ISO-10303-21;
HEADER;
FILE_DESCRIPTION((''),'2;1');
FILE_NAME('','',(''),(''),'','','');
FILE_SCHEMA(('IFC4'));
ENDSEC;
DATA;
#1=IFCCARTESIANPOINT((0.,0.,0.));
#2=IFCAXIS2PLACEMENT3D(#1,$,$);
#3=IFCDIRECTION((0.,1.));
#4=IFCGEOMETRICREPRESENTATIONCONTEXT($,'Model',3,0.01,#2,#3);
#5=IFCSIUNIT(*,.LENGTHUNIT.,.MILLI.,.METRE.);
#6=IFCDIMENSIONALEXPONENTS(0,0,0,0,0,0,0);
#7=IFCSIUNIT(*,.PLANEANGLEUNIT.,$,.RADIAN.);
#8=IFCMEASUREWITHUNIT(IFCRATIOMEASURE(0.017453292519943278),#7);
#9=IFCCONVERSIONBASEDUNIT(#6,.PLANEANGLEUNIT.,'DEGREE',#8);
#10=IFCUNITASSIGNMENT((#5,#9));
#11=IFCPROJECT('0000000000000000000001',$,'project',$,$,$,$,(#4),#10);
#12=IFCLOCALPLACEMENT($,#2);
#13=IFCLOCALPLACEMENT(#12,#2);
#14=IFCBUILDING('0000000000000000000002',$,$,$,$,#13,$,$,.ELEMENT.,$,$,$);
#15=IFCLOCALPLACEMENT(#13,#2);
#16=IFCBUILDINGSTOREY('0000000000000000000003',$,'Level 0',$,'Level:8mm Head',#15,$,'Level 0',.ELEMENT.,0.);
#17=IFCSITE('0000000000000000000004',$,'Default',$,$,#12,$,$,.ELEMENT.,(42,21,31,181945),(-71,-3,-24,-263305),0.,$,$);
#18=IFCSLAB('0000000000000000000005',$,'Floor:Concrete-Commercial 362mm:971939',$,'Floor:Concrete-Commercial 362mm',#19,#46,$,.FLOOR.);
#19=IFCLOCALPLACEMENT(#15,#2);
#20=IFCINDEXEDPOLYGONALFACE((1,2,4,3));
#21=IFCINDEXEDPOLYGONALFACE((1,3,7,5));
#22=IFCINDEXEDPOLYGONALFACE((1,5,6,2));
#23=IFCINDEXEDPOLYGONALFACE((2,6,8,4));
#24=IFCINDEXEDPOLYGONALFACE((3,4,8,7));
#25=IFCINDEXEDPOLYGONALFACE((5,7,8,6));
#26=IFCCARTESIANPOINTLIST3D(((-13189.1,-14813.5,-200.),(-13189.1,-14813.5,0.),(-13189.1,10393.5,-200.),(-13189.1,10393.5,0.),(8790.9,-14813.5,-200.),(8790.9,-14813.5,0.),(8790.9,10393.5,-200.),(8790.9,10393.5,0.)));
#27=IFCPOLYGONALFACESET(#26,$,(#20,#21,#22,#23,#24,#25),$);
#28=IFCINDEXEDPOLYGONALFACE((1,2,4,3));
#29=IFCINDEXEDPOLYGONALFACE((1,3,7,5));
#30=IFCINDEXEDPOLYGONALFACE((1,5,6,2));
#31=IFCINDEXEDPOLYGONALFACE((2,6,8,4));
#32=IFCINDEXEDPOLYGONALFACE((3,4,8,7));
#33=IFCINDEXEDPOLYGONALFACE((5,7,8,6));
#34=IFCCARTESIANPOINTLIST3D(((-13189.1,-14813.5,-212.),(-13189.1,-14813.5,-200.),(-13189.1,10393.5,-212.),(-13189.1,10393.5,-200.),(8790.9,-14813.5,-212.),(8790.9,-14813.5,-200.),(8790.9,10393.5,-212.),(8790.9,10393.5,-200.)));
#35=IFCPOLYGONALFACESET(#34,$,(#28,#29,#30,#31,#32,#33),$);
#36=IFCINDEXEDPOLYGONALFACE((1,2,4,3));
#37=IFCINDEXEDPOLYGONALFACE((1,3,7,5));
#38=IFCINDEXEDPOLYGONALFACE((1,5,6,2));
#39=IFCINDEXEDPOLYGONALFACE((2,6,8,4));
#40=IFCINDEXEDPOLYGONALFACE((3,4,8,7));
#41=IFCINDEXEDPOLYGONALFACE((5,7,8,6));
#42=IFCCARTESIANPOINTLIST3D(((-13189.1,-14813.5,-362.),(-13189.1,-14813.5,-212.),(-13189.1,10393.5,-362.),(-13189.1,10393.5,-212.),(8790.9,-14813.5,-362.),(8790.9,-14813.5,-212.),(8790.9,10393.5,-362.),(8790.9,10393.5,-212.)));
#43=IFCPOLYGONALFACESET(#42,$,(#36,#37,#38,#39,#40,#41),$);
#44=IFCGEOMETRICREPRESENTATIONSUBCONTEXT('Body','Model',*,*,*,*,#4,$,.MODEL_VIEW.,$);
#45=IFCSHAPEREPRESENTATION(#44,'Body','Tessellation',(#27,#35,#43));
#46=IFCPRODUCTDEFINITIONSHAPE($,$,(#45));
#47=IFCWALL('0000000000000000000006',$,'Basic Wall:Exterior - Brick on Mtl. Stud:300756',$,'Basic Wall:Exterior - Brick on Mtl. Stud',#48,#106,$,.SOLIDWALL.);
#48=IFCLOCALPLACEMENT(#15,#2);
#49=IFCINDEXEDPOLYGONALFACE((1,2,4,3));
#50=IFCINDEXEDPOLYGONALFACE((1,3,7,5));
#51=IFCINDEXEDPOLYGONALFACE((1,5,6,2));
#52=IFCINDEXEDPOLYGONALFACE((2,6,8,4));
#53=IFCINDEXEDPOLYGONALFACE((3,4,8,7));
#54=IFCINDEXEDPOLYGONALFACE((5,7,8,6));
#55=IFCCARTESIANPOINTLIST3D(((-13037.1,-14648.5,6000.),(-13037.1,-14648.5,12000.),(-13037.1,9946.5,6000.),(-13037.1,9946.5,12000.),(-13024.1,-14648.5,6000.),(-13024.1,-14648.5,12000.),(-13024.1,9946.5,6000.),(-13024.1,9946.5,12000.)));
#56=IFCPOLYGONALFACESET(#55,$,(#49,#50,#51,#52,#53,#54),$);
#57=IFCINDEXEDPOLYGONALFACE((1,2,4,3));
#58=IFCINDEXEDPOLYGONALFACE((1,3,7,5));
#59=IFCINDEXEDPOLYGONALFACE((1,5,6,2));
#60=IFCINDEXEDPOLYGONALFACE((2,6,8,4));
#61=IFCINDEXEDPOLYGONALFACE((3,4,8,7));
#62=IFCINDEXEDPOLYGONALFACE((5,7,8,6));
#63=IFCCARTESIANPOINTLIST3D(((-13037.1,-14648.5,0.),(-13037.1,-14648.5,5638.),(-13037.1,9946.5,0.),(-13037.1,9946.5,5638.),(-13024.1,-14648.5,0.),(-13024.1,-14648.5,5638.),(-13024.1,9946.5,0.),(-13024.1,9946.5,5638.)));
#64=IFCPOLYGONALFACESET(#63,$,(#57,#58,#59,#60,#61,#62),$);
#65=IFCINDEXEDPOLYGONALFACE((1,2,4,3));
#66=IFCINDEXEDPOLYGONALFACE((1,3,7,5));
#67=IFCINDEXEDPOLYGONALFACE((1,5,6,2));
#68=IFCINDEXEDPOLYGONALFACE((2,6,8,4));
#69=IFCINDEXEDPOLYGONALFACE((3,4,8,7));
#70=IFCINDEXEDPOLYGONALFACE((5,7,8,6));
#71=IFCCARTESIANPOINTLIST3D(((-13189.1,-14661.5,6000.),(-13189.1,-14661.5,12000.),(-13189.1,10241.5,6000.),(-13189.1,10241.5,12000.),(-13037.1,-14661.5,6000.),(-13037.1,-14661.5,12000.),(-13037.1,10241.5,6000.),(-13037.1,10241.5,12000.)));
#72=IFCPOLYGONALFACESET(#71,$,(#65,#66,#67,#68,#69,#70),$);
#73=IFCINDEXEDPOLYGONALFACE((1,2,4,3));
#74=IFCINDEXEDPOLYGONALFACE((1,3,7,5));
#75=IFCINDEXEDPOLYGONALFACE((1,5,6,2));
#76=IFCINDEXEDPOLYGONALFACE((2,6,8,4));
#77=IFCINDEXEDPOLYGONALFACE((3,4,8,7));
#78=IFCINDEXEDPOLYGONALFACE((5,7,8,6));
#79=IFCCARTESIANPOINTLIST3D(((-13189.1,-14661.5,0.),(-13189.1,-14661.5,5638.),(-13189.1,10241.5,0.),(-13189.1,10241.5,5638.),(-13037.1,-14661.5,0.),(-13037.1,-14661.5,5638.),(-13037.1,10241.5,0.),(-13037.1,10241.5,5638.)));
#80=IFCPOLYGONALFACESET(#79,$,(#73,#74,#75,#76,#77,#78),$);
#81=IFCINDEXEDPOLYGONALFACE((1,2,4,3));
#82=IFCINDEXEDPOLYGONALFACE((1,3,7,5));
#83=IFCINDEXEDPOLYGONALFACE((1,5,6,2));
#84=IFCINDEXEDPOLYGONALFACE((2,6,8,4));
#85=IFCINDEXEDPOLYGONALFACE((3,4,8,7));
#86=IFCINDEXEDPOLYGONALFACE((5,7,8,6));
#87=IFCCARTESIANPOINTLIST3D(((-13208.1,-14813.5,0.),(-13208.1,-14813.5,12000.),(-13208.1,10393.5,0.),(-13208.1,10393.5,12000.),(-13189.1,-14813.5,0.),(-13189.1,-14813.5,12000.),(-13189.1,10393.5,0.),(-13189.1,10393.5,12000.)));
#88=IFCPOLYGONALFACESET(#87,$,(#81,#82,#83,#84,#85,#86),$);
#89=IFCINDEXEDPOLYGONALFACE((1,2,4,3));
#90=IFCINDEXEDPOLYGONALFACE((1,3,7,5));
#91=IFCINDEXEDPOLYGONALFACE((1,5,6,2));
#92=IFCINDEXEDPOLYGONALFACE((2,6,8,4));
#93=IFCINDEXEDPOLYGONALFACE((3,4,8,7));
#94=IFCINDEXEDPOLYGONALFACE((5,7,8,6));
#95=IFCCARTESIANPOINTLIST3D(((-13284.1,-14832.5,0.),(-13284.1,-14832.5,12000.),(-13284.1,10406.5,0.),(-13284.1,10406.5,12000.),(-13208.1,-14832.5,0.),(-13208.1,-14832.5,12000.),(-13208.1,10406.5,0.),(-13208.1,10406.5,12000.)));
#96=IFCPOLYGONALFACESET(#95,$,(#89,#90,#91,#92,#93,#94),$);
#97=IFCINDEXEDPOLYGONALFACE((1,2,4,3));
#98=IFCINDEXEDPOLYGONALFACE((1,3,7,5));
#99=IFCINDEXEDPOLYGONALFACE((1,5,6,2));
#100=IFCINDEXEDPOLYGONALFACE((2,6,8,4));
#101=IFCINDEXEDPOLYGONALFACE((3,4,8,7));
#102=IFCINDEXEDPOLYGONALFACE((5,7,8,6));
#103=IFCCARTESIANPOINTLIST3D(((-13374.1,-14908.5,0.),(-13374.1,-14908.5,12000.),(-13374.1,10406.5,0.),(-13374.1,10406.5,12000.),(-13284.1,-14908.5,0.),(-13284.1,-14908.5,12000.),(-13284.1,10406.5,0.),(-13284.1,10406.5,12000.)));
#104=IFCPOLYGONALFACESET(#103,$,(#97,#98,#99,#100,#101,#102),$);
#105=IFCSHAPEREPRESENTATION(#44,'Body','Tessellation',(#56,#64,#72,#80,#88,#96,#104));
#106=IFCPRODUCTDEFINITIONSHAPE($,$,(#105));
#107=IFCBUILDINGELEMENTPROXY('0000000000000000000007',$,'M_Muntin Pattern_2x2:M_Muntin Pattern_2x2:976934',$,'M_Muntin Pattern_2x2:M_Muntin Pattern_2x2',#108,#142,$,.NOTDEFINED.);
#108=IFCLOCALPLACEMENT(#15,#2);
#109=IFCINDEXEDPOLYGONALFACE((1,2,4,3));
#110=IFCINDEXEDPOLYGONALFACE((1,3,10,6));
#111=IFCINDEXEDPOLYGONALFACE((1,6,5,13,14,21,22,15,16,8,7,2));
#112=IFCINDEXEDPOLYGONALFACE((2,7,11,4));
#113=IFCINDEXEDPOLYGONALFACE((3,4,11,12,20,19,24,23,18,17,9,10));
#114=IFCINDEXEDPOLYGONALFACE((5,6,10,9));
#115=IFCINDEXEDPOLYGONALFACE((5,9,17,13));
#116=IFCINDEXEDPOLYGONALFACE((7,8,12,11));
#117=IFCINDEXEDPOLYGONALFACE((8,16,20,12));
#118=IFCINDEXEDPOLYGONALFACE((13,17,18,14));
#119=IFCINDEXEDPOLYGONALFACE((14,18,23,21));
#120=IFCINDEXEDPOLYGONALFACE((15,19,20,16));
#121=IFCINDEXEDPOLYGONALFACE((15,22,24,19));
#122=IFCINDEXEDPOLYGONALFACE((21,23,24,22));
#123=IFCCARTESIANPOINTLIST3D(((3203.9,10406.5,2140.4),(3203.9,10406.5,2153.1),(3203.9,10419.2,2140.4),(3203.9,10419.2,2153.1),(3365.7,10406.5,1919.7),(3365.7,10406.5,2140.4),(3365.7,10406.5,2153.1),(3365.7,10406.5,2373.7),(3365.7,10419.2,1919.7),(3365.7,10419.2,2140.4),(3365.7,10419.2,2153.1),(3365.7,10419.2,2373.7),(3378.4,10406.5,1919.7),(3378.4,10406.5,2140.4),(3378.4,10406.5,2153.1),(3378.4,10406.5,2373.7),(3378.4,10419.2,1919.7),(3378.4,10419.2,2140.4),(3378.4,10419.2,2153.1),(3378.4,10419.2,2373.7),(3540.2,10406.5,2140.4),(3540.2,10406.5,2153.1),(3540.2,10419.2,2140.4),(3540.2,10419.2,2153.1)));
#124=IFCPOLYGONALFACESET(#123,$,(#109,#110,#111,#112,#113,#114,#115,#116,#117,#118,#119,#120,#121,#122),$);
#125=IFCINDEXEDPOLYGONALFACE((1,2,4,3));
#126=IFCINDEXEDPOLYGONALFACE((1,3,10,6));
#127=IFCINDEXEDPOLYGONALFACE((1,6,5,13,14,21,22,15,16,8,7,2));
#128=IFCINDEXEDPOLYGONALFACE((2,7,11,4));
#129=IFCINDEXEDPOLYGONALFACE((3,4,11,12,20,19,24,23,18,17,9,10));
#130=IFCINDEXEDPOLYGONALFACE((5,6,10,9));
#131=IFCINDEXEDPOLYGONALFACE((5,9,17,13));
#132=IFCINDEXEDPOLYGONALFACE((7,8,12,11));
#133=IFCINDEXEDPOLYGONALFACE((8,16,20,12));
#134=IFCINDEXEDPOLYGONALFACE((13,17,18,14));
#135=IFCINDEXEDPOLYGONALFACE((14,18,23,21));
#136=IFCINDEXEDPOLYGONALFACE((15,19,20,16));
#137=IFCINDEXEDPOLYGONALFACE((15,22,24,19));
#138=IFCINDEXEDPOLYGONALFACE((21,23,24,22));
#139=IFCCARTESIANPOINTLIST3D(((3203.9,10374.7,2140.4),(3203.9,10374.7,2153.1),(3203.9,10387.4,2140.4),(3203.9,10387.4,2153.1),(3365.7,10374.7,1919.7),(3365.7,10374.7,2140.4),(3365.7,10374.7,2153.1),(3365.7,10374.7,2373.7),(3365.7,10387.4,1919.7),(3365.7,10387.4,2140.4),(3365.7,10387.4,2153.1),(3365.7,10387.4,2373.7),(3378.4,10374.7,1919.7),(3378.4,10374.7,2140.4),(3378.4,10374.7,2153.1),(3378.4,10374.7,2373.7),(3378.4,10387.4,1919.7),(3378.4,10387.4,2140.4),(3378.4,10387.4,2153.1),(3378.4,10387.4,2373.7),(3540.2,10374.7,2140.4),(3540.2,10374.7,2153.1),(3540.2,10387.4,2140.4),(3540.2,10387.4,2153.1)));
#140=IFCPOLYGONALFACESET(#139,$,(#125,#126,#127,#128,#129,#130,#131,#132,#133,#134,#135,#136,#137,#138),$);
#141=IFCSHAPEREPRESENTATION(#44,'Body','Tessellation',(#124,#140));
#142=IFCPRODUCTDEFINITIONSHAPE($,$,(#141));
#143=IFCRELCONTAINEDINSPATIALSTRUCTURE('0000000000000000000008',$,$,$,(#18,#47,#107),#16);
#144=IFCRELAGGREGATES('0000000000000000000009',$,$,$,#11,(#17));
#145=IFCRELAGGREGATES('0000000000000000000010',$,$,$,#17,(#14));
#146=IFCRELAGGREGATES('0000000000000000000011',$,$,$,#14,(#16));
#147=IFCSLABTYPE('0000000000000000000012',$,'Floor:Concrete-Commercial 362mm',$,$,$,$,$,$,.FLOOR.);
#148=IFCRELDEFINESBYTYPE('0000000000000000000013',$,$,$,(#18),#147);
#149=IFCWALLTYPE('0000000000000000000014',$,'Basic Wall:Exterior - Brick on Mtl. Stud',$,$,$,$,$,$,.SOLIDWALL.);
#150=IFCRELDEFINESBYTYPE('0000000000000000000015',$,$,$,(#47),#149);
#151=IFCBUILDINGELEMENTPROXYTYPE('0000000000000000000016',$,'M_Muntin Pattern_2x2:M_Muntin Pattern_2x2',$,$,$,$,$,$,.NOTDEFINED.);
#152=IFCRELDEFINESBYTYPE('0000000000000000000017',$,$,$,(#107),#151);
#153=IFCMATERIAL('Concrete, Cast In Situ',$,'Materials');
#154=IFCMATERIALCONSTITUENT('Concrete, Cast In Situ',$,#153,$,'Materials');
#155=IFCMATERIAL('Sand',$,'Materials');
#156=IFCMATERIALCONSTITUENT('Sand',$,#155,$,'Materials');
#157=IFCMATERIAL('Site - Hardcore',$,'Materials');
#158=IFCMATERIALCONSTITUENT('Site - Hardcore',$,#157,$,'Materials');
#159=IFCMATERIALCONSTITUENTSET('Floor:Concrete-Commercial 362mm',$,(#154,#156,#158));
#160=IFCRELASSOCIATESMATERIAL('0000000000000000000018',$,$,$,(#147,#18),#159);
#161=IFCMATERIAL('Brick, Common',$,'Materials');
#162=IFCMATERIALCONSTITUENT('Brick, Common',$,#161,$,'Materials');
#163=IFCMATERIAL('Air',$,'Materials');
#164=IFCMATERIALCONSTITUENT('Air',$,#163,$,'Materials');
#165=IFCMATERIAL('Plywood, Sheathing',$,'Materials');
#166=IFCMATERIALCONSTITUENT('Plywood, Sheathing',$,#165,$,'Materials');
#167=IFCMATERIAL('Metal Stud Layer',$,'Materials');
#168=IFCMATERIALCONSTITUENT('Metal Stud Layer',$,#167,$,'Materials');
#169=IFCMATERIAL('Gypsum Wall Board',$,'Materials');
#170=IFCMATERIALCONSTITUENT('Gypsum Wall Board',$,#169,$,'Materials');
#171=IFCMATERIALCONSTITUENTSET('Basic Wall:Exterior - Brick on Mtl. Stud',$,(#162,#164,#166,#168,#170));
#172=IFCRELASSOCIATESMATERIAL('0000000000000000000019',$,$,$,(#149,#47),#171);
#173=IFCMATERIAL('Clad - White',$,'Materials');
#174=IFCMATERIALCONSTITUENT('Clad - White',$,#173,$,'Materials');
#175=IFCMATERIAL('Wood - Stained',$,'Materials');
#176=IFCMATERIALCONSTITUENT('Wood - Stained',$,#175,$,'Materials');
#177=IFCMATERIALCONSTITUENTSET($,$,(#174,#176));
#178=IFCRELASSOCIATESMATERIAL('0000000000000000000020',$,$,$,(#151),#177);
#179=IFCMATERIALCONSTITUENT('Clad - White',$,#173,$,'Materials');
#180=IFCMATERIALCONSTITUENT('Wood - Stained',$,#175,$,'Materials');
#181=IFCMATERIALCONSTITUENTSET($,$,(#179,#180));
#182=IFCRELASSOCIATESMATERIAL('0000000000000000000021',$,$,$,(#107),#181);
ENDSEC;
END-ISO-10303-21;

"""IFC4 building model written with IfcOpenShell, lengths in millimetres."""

from ifc_helpers import new_model, entity, si_unit, converted_unit, direction, frame, origin, place, context, subcontext, project, spatial, indexed_curve, outline, extrude, source, transform, mapped, material, constituent, constituent_set, type_object, type_shapes, element, save


model = new_model("IFC4")

# Units and contexts
model_context = context("Model", 3, precision=0.01, world=origin(), true_north=direction((0.0, 1.0)))
body_context = subcontext(model_context, "Body", "Model", "MODEL_VIEW")
ifc_project = project(units=[si_unit("LENGTHUNIT", "METRE", prefix="MILLI"), converted_unit("PLANEANGLEUNIT", "DEGREE", entity("IfcRatioMeasure", 0.017453292519943278), si_unit("PLANEANGLEUNIT", "RADIAN"), dimensions=[0, 0, 0, 0, 0, 0, 0])], contexts=[model_context])

# Site, building, storey
site_placement = place(None, origin())
site = spatial("IfcSite", under=ifc_project, at=site_placement, Name="Default", CompositionType="ELEMENT", RefLatitude=(42, 21, 31, 181945), RefLongitude=(-71, -3, -24, -263305), RefElevation=0.0)
building_placement = place(site_placement, origin())
building = spatial("IfcBuilding", under=site, at=building_placement, CompositionType="ELEMENT")
storey_placement = place(building_placement, origin())
storey = spatial("IfcBuildingStorey", under=building, at=storey_placement, Name="Level 0", ObjectType="Level:8mm Head", LongName="Level 0", CompositionType="ELEMENT", Elevation=0.0)

# Slab
ifc_material_1 = material(Name="Concrete, Cast In Situ", Category="Materials")
ifc_constituent_1 = constituent(ifc_material_1, Name="Concrete, Cast In Situ", Category="Materials")
ifc_material_2 = material(Name="Sand", Category="Materials")
ifc_constituent_2 = constituent(ifc_material_2, Name="Sand", Category="Materials")
ifc_material_3 = material(Name="Site - Hardcore", Category="Materials")
ifc_constituent_3 = constituent(ifc_material_3, Name="Site - Hardcore", Category="Materials")
ifc_constituent_set_1 = constituent_set(constituents=[ifc_constituent_1, ifc_constituent_2, ifc_constituent_3], Name="Floor:Concrete-Commercial 362mm")
slab_type = type_object("IfcSlabType", Name="Floor:Concrete-Commercial 362mm", PredefinedType="FLOOR", material=ifc_constituent_set_1)
slab_placement = place(storey_placement, origin())
element("IfcSlab", 1, at=slab_placement, inside=storey, type_object=slab_type, material=ifc_constituent_set_1, Name="Floor:Concrete-Commercial 362mm:971939", ObjectType="Floor:Concrete-Commercial 362mm", PredefinedType="FLOOR", context=body_context, shape_type="SweptSolid", body=[
    extrude(outline(indexed_curve([(-10990.0, -12603.5), (10990.0, -12603.5), (10990.0, 12603.5), (-10990.0, 12603.5), (-10990.0, -12603.5)], self_intersect=False)), frame((-2199.1, -2210.0, -200.0), z_axis=(0.0, 0.0, 1.0), x_axis=(-1.0, 0.0, 0.0)), (0.0, 0.0, 1.0), 200.0),
    extrude(outline(indexed_curve([(-10990.0, -12603.5), (10990.0, -12603.5), (10990.0, 12603.5), (-10990.0, 12603.5), (-10990.0, -12603.5)], self_intersect=False)), frame((-2199.1, -2210.0, -212.0), z_axis=(0.0, 0.0, 1.0), x_axis=(-1.0, 0.0, 0.0)), (0.0, 0.0, 1.0), 12.0),
    extrude(outline(indexed_curve([(-10990.0, -12603.5), (10990.0, -12603.5), (10990.0, 12603.5), (-10990.0, 12603.5), (-10990.0, -12603.5)], self_intersect=False)), frame((-2199.1, -2210.0, -362.0), z_axis=(0.0, 0.0, 1.0), x_axis=(-1.0, 0.0, 0.0)), (0.0, 0.0, 1.0), 150.0),
])

# Shared definitions
ifc_material_4 = material(Name="Air", Category="Materials")
ifc_material_5 = material(Name="Plywood, Sheathing", Category="Materials")
ifc_material_6 = material(Name="Metal Stud Layer", Category="Materials")
ifc_material_7 = material(Name="Gypsum Wall Board", Category="Materials")
ifc_material_8 = material(Name="Brick, Common", Category="Materials")
ifc_constituent_4 = constituent(ifc_material_8, Name="Brick, Common", Category="Materials")
ifc_constituent_5 = constituent(ifc_material_4, Name="Air", Category="Materials")
ifc_constituent_6 = constituent(ifc_material_5, Name="Plywood, Sheathing", Category="Materials")
ifc_constituent_7 = constituent(ifc_material_6, Name="Metal Stud Layer", Category="Materials")
ifc_constituent_8 = constituent(ifc_material_7, Name="Gypsum Wall Board", Category="Materials")
ifc_constituent_set_2 = constituent_set(constituents=[ifc_constituent_4, ifc_constituent_5, ifc_constituent_6, ifc_constituent_7, ifc_constituent_8], Name="Basic Wall:Exterior - Brick on Mtl. Stud")
wall_type_1 = type_object("IfcWallType", Name="Basic Wall:Exterior - Brick on Mtl. Stud", PredefinedType="SOLIDWALL", material=ifc_constituent_set_2)

# Wall
wall_1_placement = place(storey_placement, frame((-13199.1, -14648.5, 0.0), z_axis=(0.0, 0.0, 1.0), x_axis=(0.0, 1.0, 0.0)))
element("IfcWall", 2, at=wall_1_placement, inside=storey, type_object=wall_type_1, material=ifc_constituent_set_2, Name="Basic Wall:Exterior - Brick on Mtl. Stud:300756", ObjectType="Basic Wall:Exterior - Brick on Mtl. Stud", PredefinedType="SOLIDWALL", context=body_context, shape_type="SweptSolid", body=[
    extrude(outline(indexed_curve([(-3000.0, -12297.5), (3000.0, -12297.5), (3000.0, 12297.5), (-3000.0, 12297.5), (-3000.0, -12297.5)], self_intersect=False)), frame((12297.5, -162.0, 9000.0), z_axis=(0.0, -1.0, 0.0), x_axis=(0.0, 0.0, -1.0)), (0.0, 0.0, 1.0), 13.0),
    extrude(outline(indexed_curve([(-2819.0, -12297.5), (2819.0, -12297.5), (2819.0, 12297.5), (-2819.0, 12297.5), (-2819.0, -12297.5)], self_intersect=False)), frame((12297.5, -162.0, 2819.0), z_axis=(0.0, -1.0, 0.0), x_axis=(0.0, 0.0, 1.0)), (0.0, 0.0, 1.0), 13.0),
    extrude(outline(indexed_curve([(-3000.0, -12451.5), (3000.0, -12451.5), (3000.0, 12451.5), (-3000.0, 12451.5), (-3000.0, -12451.5)], self_intersect=False)), frame((12438.5, -10.0, 9000.0), z_axis=(0.0, -1.0, 0.0), x_axis=(0.0, 0.0, -1.0)), (0.0, 0.0, 1.0), 152.0),
    extrude(outline(indexed_curve([(-2819.0, -12451.5), (2819.0, -12451.5), (2819.0, 12451.5), (-2819.0, 12451.5), (-2819.0, -12451.5)], self_intersect=False)), frame((12438.5, -10.0, 2819.0), z_axis=(0.0, -1.0, 0.0), x_axis=(0.0, 0.0, 1.0)), (0.0, 0.0, 1.0), 152.0),
    extrude(outline(indexed_curve([(-12603.5, -9.5), (12603.5, -9.5), (12603.5, 9.5), (-12603.5, 9.5), (-12603.5, -9.5)], self_intersect=False)), frame((12438.5, -0.5, 0.0)), (0.0, 0.0, 1.0), 12000.0),
    extrude(outline(indexed_curve([(-12619.5, -38.0), (12619.5, -38.0), (12619.5, 38.0), (-12619.5, 38.0), (-12619.5, -38.0)], self_intersect=False)), frame((12435.5, 47.0, 0.0)), (0.0, 0.0, 1.0), 12000.0),
    extrude(outline(indexed_curve([(-45.0, -12657.5), (45.0, -12657.5), (45.0, 12657.5), (-45.0, 12657.5), (-45.0, -12657.5)], self_intersect=False)), frame((12397.5, 130.0, 0.0), z_axis=(0.0, 0.0, 1.0), x_axis=(0.0, -1.0, 0.0)), (0.0, 0.0, 1.0), 12000.0),
])

# Building element proxy
ifc_material_9 = material(Name="Clad - White", Category="Materials")
ifc_constituent_9 = constituent(ifc_material_9, Name="Clad - White", Category="Materials")
ifc_material_10 = material(Name="Wood - Stained", Category="Materials")
ifc_constituent_10 = constituent(ifc_material_10, Name="Wood - Stained", Category="Materials")
ifc_constituent_set_3 = constituent_set(constituents=[ifc_constituent_9, ifc_constituent_10])
ifc_constituent_11 = constituent(ifc_material_9, Name="Clad - White", Category="Materials")
ifc_constituent_12 = constituent(ifc_material_10, Name="Wood - Stained", Category="Materials")
ifc_constituent_set_4 = constituent_set(constituents=[ifc_constituent_11, ifc_constituent_12])
building_element_proxy_type_1 = type_object("IfcBuildingElementProxyType", Name="M_Muntin Pattern_2x2:M_Muntin Pattern_2x2", PredefinedType="NOTDEFINED", material=ifc_constituent_set_4)
shared_shape_1 = source(origin(), body_context, "Body", "SweptSolid", [
    extrude(outline(indexed_curve([(6.4, -6.4), (227.0, -6.4), (227.0, 6.3), (6.4, 6.3), (6.4, 168.2), (-6.3, 168.2), (-6.3, 6.3), (-227.0, 6.3), (-227.0, -6.4), (-6.3, -6.4), (-6.3, -168.1), (6.4, -168.1), (6.4, -6.4)], self_intersect=False)), frame((0.0, 9.5, 227.0), z_axis=(0.0, 1.0, 0.0), x_axis=(0.0, 0.0, 1.0)), (0.0, 0.0, 1.0), 12.7),
    extrude(outline(indexed_curve([(6.4, -6.4), (227.0, -6.4), (227.0, 6.3), (6.4, 6.3), (6.4, 168.2), (-6.3, 168.2), (-6.3, 6.3), (-227.0, 6.3), (-227.0, -6.4), (-6.3, -6.4), (-6.3, -168.1), (6.4, -168.1), (6.4, -6.4)], self_intersect=False)), frame((0.0, -22.2, 227.0), z_axis=(0.0, 1.0, 0.0), x_axis=(0.0, 0.0, 1.0)), (0.0, 0.0, 1.0), 12.7),
])
type_shapes(building_element_proxy_type_1, [shared_shape_1])
proxy_1_placement = place(storey_placement, frame((3372.1, 10396.9, 1919.7)))
element("IfcBuildingElementProxy", 3, at=proxy_1_placement, inside=storey, type_object=building_element_proxy_type_1, material=ifc_constituent_set_3, Name="M_Muntin Pattern_2x2:M_Muntin Pattern_2x2:976934", ObjectType="M_Muntin Pattern_2x2:M_Muntin Pattern_2x2", PredefinedType="NOTDEFINED", context=body_context, shape_type="MappedRepresentation", body=[
    mapped(shared_shape_1, transform((0.0, 0.0, 0.0), scale=1.0)),
])

save(model, "model.ifc")
